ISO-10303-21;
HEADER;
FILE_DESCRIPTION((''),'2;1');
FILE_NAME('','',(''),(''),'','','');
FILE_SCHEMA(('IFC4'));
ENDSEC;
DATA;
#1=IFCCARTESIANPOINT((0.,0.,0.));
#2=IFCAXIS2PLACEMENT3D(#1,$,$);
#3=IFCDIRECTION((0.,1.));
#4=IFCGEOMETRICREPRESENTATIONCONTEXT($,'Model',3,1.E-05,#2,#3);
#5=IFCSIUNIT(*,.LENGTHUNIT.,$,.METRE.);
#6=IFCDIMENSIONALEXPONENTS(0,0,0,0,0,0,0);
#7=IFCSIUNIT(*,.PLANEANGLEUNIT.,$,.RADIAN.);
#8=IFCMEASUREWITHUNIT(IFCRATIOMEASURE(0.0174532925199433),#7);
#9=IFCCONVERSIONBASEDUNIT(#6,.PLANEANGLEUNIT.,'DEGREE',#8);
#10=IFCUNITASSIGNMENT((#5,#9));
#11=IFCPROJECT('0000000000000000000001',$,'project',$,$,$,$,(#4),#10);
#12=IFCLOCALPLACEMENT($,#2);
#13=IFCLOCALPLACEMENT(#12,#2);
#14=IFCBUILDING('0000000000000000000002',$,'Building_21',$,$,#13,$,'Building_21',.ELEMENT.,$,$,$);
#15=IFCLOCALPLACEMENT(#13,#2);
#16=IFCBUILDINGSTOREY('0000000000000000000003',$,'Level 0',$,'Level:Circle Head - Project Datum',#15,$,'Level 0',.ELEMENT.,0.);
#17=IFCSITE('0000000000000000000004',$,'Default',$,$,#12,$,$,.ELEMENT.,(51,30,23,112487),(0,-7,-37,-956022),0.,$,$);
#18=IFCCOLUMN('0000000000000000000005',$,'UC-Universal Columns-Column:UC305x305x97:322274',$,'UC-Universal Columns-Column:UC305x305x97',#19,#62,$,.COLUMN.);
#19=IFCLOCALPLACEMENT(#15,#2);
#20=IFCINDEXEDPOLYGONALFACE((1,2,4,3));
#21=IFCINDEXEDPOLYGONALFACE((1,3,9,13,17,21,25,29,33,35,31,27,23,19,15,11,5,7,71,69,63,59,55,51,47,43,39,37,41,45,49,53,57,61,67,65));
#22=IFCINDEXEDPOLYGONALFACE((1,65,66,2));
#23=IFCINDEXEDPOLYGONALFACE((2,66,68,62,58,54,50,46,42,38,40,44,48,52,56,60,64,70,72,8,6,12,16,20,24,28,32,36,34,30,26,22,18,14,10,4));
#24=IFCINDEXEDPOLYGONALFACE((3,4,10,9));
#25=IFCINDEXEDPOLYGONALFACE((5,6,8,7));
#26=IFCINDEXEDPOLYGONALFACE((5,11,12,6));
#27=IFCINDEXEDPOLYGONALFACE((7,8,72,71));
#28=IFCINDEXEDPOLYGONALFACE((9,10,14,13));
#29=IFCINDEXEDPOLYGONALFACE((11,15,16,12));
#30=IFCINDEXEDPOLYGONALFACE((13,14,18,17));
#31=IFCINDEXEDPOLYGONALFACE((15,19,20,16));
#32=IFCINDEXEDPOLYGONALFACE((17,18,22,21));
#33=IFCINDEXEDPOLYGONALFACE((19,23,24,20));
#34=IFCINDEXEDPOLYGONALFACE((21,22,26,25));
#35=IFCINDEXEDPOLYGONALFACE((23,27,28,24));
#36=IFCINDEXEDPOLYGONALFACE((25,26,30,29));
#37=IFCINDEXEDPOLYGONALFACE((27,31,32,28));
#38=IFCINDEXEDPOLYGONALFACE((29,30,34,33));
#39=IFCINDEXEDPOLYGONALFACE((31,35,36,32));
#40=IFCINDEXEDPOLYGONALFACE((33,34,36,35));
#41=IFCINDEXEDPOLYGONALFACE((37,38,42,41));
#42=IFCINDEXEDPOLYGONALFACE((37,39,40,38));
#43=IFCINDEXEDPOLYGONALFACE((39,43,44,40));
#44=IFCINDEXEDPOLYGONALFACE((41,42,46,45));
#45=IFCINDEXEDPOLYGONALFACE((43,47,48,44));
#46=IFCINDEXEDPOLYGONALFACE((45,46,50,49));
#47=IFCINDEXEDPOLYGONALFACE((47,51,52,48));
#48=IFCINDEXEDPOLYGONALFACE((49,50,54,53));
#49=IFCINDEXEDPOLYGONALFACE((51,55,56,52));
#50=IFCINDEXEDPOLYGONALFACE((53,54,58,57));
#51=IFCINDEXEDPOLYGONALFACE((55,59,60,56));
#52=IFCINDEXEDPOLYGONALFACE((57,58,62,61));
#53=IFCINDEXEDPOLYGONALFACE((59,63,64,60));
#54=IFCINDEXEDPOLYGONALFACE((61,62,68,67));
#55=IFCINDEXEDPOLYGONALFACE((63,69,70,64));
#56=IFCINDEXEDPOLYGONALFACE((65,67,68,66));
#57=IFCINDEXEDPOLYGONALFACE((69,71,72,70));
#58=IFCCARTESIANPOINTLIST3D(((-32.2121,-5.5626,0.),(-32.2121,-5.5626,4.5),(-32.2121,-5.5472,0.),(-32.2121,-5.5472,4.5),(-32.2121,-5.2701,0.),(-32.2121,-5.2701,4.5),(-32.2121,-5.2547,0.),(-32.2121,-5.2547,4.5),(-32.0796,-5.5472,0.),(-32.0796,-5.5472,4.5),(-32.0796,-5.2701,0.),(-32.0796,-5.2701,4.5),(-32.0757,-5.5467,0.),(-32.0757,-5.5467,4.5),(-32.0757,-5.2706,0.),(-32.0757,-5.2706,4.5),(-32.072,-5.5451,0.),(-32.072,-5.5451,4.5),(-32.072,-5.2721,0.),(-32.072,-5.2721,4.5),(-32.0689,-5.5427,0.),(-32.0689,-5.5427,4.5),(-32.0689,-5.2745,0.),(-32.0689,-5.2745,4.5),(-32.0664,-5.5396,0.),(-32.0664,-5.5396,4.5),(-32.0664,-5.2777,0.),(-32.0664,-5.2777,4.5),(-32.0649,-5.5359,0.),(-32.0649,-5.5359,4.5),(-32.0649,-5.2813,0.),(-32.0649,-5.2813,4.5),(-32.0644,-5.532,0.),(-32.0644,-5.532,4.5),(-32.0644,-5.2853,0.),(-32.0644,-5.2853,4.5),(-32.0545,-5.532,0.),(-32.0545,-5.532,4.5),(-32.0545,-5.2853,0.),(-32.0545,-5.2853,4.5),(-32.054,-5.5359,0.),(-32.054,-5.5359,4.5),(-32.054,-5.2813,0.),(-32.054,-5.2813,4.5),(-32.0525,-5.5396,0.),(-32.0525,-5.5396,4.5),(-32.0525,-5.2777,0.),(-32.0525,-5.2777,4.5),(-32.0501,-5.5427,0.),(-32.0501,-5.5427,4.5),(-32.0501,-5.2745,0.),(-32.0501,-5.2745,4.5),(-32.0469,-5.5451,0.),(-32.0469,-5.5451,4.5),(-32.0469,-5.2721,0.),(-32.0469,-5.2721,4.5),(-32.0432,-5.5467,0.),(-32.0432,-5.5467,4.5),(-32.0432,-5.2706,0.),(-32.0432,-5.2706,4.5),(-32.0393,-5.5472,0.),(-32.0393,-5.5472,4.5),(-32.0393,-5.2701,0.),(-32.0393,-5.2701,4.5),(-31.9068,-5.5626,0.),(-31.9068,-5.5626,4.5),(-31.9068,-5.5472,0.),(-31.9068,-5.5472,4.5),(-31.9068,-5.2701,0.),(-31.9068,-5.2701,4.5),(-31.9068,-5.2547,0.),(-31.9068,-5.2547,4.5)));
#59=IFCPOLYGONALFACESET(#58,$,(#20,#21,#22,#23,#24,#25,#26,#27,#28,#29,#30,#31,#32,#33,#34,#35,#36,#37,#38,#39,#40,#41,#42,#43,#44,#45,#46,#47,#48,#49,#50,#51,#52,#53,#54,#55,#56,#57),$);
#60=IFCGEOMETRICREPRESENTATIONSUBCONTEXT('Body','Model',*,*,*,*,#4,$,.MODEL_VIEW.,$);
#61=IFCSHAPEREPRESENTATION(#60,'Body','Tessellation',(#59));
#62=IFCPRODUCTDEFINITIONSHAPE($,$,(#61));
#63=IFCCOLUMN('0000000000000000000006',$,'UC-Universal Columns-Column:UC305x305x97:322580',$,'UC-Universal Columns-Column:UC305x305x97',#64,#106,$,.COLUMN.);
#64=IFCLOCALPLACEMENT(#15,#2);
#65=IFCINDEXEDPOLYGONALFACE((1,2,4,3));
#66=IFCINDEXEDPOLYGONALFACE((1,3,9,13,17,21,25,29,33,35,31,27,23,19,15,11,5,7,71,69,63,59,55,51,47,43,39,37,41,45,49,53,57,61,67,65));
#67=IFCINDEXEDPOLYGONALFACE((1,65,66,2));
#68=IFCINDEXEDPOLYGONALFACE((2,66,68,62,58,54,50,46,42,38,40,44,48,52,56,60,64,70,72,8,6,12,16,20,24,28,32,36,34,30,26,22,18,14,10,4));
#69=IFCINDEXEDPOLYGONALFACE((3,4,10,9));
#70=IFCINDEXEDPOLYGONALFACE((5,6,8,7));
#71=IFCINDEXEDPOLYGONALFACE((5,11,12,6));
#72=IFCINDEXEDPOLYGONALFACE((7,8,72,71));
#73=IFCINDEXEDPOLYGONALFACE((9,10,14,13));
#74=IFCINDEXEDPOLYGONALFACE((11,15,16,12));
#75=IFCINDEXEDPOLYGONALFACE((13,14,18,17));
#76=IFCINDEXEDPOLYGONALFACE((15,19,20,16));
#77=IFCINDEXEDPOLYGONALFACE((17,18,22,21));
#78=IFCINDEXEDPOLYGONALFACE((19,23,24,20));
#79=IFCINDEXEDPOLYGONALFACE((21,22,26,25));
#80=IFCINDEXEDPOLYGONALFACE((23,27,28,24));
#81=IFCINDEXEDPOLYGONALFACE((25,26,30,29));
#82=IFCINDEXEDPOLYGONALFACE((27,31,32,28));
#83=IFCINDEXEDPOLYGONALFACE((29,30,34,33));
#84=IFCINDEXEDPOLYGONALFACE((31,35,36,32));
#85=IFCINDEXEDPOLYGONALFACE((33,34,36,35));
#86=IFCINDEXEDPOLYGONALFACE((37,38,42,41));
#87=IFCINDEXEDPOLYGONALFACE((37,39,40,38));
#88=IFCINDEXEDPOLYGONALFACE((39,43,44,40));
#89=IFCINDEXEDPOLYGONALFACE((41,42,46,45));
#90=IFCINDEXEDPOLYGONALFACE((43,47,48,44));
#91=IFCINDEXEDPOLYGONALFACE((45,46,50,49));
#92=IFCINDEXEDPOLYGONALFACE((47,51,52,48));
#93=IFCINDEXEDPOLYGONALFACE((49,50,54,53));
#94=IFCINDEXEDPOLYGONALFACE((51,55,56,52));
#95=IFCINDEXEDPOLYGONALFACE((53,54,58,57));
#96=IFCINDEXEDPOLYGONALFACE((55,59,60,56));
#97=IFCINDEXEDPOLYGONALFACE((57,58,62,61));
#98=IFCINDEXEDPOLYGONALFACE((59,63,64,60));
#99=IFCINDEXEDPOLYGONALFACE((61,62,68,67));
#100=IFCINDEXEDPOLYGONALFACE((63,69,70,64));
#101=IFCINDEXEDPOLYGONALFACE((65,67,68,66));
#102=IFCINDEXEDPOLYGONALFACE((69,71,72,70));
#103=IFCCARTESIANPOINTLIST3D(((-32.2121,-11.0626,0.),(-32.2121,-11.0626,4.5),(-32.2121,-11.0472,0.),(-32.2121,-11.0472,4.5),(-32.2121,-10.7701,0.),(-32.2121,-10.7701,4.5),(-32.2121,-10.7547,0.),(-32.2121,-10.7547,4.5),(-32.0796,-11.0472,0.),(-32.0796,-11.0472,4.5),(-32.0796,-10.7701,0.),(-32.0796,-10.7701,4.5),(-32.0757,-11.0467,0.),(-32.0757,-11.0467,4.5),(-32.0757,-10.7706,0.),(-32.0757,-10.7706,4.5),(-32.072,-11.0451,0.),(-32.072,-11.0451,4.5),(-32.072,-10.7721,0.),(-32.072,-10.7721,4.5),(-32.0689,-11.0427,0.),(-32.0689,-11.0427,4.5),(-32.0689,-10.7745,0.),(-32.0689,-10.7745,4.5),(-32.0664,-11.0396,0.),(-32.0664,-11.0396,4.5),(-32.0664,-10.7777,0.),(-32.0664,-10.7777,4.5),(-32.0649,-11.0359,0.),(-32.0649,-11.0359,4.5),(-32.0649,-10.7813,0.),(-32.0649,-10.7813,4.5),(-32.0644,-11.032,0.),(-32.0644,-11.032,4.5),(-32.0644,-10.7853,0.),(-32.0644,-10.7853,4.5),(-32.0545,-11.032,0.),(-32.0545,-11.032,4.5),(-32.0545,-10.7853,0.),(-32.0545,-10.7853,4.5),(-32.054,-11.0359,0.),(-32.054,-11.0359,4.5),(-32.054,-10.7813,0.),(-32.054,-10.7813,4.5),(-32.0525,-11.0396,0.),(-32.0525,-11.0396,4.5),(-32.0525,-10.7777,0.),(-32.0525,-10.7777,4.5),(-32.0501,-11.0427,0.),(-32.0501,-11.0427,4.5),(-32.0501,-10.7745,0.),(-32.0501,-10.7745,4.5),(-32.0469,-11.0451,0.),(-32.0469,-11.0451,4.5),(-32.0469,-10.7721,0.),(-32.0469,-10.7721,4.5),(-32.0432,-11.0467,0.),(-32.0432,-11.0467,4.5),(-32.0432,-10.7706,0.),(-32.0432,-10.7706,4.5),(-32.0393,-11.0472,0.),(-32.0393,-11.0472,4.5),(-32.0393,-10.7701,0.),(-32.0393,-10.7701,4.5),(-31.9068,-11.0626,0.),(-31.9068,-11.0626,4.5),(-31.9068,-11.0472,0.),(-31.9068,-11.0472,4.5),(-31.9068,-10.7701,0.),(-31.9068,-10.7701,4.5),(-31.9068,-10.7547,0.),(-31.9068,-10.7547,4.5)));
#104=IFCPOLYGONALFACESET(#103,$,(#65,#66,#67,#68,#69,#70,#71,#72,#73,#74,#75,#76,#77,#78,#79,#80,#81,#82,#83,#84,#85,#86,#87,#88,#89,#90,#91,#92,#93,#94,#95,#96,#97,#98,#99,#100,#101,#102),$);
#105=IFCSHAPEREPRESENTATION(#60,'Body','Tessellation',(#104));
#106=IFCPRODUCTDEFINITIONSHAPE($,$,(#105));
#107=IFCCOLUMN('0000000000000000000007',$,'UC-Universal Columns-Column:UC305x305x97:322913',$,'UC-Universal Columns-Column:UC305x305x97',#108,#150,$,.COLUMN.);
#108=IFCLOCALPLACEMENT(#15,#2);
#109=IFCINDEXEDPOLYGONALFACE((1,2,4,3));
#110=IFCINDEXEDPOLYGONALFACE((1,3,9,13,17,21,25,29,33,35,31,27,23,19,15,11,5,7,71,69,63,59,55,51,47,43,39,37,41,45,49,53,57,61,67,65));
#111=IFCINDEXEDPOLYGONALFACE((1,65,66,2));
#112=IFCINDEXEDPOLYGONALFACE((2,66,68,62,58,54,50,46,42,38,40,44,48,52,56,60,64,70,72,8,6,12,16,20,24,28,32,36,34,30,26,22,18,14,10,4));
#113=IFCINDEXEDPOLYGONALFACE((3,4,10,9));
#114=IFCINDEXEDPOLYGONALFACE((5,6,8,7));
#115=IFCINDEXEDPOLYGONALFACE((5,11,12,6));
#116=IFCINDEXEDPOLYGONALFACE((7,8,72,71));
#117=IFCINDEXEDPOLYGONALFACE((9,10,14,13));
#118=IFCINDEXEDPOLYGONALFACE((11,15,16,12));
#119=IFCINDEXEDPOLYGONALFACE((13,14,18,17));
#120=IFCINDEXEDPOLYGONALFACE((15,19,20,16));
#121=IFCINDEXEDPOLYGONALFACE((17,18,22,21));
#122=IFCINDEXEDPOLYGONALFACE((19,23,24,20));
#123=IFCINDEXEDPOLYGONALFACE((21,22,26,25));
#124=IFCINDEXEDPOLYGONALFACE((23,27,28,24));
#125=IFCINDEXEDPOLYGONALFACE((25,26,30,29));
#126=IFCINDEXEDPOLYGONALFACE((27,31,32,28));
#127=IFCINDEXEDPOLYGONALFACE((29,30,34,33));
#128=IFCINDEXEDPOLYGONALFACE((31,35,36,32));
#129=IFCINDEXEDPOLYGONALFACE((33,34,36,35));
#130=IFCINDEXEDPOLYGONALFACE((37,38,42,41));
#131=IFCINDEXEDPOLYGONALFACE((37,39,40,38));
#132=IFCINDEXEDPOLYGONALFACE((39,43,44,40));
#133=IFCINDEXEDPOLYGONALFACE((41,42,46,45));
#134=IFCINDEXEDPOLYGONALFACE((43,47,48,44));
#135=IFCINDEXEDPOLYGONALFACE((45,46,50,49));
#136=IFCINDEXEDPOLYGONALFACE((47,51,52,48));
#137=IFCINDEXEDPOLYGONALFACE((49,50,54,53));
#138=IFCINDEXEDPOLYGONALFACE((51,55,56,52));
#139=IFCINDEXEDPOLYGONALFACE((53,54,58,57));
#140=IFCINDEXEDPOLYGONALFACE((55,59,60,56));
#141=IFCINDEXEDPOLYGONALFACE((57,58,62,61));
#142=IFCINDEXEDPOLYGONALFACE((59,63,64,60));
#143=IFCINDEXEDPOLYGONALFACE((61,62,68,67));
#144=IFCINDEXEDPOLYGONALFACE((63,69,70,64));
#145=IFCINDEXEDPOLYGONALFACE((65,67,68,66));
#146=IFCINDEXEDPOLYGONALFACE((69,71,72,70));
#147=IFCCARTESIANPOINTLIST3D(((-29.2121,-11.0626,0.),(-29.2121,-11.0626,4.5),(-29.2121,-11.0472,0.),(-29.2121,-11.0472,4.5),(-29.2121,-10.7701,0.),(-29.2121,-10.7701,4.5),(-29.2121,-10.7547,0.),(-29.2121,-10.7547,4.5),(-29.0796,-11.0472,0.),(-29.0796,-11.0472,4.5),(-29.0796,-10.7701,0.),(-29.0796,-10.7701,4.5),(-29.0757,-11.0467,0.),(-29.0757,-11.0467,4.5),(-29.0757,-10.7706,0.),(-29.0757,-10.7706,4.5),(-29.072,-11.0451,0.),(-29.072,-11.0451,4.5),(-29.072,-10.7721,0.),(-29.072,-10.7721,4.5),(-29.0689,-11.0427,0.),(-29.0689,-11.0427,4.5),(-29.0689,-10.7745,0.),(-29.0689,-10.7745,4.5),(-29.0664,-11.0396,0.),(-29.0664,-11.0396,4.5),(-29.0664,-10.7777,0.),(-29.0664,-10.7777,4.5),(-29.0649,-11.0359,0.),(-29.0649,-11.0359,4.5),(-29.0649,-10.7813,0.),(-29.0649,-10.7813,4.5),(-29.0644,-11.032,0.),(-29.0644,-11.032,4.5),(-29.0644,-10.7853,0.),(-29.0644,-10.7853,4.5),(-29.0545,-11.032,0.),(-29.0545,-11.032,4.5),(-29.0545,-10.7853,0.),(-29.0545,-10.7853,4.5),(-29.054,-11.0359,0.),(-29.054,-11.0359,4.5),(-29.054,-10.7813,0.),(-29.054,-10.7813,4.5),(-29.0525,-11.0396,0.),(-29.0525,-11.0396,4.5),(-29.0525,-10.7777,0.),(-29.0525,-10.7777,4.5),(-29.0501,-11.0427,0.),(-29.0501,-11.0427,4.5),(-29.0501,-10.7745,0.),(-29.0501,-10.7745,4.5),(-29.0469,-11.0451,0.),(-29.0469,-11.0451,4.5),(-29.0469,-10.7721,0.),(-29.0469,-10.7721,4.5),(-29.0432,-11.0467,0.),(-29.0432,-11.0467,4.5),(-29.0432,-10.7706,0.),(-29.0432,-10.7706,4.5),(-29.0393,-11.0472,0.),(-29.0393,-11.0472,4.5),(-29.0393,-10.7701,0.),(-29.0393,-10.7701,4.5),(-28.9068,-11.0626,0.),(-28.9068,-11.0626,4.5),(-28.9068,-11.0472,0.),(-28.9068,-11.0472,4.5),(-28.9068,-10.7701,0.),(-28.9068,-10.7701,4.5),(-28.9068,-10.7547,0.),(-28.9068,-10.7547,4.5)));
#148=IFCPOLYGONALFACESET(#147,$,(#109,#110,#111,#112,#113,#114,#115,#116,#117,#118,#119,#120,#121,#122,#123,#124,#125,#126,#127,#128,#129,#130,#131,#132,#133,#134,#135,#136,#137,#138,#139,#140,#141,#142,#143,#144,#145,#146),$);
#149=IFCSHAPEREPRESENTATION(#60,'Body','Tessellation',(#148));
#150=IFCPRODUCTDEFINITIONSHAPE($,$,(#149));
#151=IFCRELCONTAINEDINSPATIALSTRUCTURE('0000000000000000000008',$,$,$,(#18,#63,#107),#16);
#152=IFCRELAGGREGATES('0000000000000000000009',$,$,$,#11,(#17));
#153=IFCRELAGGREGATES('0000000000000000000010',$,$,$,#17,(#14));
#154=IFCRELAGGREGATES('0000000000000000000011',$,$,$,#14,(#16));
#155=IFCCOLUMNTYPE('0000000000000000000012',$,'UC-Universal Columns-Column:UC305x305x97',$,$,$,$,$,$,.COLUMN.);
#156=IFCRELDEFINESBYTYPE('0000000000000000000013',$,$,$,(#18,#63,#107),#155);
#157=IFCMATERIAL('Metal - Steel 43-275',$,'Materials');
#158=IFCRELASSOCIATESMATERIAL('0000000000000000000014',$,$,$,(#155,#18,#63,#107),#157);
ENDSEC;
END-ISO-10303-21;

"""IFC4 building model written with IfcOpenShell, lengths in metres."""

from ifc_helpers import new_model, entity, si_unit, converted_unit, direction, frame, frame_2d, origin, place, context, subcontext, project, spatial, polyline, circle_curve, parameter, trimmed, segment, composite_curve, i_section, outline, extrude, source, transform, mapped, material, material_profile, profile_set, profile_usage, type_object, type_shapes, element, save


model = new_model("IFC4")

# Units and contexts
model_context = context("Model", 3, precision=1e-05, world=origin(), true_north=direction((0.0, 1.0)))
body_context = subcontext(model_context, "Body", "Model", "MODEL_VIEW")
ifc_project = project(units=[si_unit("LENGTHUNIT", "METRE"), converted_unit("PLANEANGLEUNIT", "DEGREE", entity("IfcRatioMeasure", 0.0174532925199433), si_unit("PLANEANGLEUNIT", "RADIAN"), dimensions=[0, 0, 0, 0, 0, 0, 0])], contexts=[model_context])

# Site, building, storey
site_placement = place(None, origin())
site = spatial("IfcSite", under=ifc_project, at=site_placement, Name="Default", CompositionType="ELEMENT", RefLatitude=(51, 30, 23, 112487), RefLongitude=(0, -7, -37, -956022), RefElevation=0.0)
building_placement = place(site_placement, origin())
building = spatial("IfcBuilding", under=site, at=building_placement, Name="Building_21", LongName="Building_21", CompositionType="ELEMENT")
storey_placement = place(building_placement, origin())
storey = spatial("IfcBuildingStorey", under=building, at=storey_placement, Name="Level 0", ObjectType="Level:Circle Head - Project Datum", LongName="Level 0", CompositionType="ELEMENT", Elevation=0.0)

# Columns
ifc_material_1 = material(Name="Metal - Steel 43-275", Category="Materials")
ifc_material_profile_1 = material_profile(ifc_material_1, outline(composite_curve([segment(polyline([(-0.1527, 0.154, 0.0), (0.1527, 0.154, 0.0)]), True, "CONTINUOUS"), segment(polyline([(0.1527, 0.154, 0.0), (0.1527, 0.1386, 0.0)]), True, "CONTINUOUS"), segment(polyline([(0.1527, 0.1386, 0.0), (0.0201, 0.1386, 0.0)]), True, "CONTINUOUS"), segment(trimmed(circle_curve(frame((0.0201, 0.1234, 0.0)), 0.0152), [parameter(90.0)], [parameter(180.0)], True, "PARAMETER"), True, "CONTINUOUS"), segment(polyline([(0.0049, 0.1234, 0.0), (0.0049, -0.1234, 0.0)]), True, "CONTINUOUS"), segment(trimmed(circle_curve(frame((0.0201, -0.1234, 0.0)), 0.0152), [parameter(180.0)], [parameter(270.0)], True, "PARAMETER"), True, "CONTINUOUS"), segment(polyline([(0.0201, -0.1386, 0.0), (0.1527, -0.1386, 0.0)]), True, "CONTINUOUS"), segment(polyline([(0.1527, -0.1386, 0.0), (0.1527, -0.154, 0.0)]), True, "CONTINUOUS"), segment(polyline([(0.1527, -0.154, 0.0), (-0.1527, -0.154, 0.0)]), True, "CONTINUOUS"), segment(polyline([(-0.1527, -0.154, 0.0), (-0.1527, -0.1386, 0.0)]), True, "CONTINUOUS"), segment(polyline([(-0.1527, -0.1386, 0.0), (-0.0201, -0.1386, 0.0)]), True, "CONTINUOUS"), segment(trimmed(circle_curve(frame((-0.0201, -0.1234, 0.0)), 0.0152), [parameter(270.0)], [parameter(0.0)], True, "PARAMETER"), True, "CONTINUOUS"), segment(polyline([(-0.0049, -0.1234, 0.0), (-0.005, 0.1234, 0.0)]), True, "CONTINUOUS"), segment(trimmed(circle_curve(frame((-0.0201, 0.1234, 0.0)), 0.0152), [parameter(0.0)], [parameter(90.0)], True, "PARAMETER"), True, "CONTINUOUS"), segment(polyline([(-0.0201, 0.1386, 0.0), (-0.1527, 0.1386, 0.0)]), True, "CONTINUOUS"), segment(polyline([(-0.1527, 0.1386, 0.0), (-0.1527, 0.154, 0.0)]), True, "CONTINUOUS")], self_intersect=False), kind="CURVE"), Name="UC305x305x97")
ifc_material_profile_2 = material_profile(ifc_material_1, outline(composite_curve([segment(polyline([(0.1527, 0.154, 0.0), (0.1527, 0.1386, 0.0)]), True, "CONTINUOUS"), segment(polyline([(0.1527, 0.1386, 0.0), (0.0049, 0.1386, 0.0)]), True, "CONTINUOUS"), segment(polyline([(0.0049, 0.1386, 0.0), (0.0049, -0.1386, 0.0)]), True, "CONTINUOUS"), segment(polyline([(0.0049, -0.1386, 0.0), (0.1527, -0.1386, 0.0)]), True, "CONTINUOUS"), segment(polyline([(0.1527, -0.1386, 0.0), (0.1527, -0.154, 0.0)]), True, "CONTINUOUS"), segment(polyline([(0.1527, -0.154, 0.0), (-0.1527, -0.154, 0.0)]), True, "CONTINUOUS"), segment(polyline([(-0.1527, -0.154, 0.0), (-0.1527, -0.1386, 0.0)]), True, "CONTINUOUS"), segment(polyline([(-0.1527, -0.1386, 0.0), (-0.005, -0.1386, 0.0)]), True, "CONTINUOUS"), segment(polyline([(-0.005, -0.1386, 0.0), (-0.005, 0.1386, 0.0)]), True, "CONTINUOUS"), segment(polyline([(-0.005, 0.1386, 0.0), (-0.1527, 0.1386, 0.0)]), True, "CONTINUOUS"), segment(polyline([(-0.1527, 0.1386, 0.0), (-0.1527, 0.154, 0.0)]), True, "CONTINUOUS"), segment(polyline([(-0.1527, 0.154, 0.0), (0.1527, 0.154, 0.0)]), True, "CONTINUOUS")], self_intersect=False), kind="CURVE"), Name="UC305x305x97")
ifc_profile_set = profile_set([ifc_material_profile_1, ifc_material_profile_2], Name="UC305x305x97")
ifc_profile_usage_1 = profile_usage(ifc_profile_set)
column_type = type_object("IfcColumnType", Name="UC-Universal Columns-Column:UC305x305x97", PredefinedType="COLUMN", material=ifc_profile_set)
shared_shape = source(origin(), body_context, "Body", "SweptSolid", [
    extrude(i_section(OverallWidth=0.3053, OverallDepth=0.3079, WebThickness=0.0099, FlangeThickness=0.0154, FilletRadius=0.0152, at=frame_2d((0.0, 0.0), x_axis=(0.0, 1.0))), frame((0.0, 0.0, 0.0), z_axis=(0.0, 0.0, 1.0), x_axis=(0.0, -1.0, 0.0)), (0.0, 0.0, 1.0), 4.5),
])
type_shapes(column_type, [shared_shape])
column_1_placement = place(storey_placement, frame((-32.0595, -5.4086, 0.0)))
element("IfcColumn", 1, at=column_1_placement, inside=storey, type_object=column_type, material=ifc_profile_usage_1, Name="UC-Universal Columns-Column:UC305x305x97:322274", ObjectType="UC-Universal Columns-Column:UC305x305x97", PredefinedType="COLUMN", context=body_context, shape_type="MappedRepresentation", body=[
    mapped(shared_shape, transform((0.0, 0.0, 0.0), scale=1.0)),
])
ifc_profile_usage_2 = profile_usage(ifc_profile_set)
column_2_placement = place(storey_placement, frame((-32.0595, -10.9086, 0.0)))
element("IfcColumn", 2, at=column_2_placement, inside=storey, type_object=column_type, material=ifc_profile_usage_2, Name="UC-Universal Columns-Column:UC305x305x97:322580", ObjectType="UC-Universal Columns-Column:UC305x305x97", PredefinedType="COLUMN", context=body_context, shape_type="MappedRepresentation", body=[
    mapped(shared_shape, transform((0.0, 0.0, 0.0), scale=1.0)),
])
ifc_profile_usage_3 = profile_usage(ifc_profile_set)
column_3_placement = place(storey_placement, frame((-29.0595, -10.9086, 0.0)))
element("IfcColumn", 3, at=column_3_placement, inside=storey, type_object=column_type, material=ifc_profile_usage_3, Name="UC-Universal Columns-Column:UC305x305x97:322913", ObjectType="UC-Universal Columns-Column:UC305x305x97", PredefinedType="COLUMN", context=body_context, shape_type="MappedRepresentation", body=[
    mapped(shared_shape, transform((0.0, 0.0, 0.0), scale=1.0)),
])

save(model, "model.ifc")
